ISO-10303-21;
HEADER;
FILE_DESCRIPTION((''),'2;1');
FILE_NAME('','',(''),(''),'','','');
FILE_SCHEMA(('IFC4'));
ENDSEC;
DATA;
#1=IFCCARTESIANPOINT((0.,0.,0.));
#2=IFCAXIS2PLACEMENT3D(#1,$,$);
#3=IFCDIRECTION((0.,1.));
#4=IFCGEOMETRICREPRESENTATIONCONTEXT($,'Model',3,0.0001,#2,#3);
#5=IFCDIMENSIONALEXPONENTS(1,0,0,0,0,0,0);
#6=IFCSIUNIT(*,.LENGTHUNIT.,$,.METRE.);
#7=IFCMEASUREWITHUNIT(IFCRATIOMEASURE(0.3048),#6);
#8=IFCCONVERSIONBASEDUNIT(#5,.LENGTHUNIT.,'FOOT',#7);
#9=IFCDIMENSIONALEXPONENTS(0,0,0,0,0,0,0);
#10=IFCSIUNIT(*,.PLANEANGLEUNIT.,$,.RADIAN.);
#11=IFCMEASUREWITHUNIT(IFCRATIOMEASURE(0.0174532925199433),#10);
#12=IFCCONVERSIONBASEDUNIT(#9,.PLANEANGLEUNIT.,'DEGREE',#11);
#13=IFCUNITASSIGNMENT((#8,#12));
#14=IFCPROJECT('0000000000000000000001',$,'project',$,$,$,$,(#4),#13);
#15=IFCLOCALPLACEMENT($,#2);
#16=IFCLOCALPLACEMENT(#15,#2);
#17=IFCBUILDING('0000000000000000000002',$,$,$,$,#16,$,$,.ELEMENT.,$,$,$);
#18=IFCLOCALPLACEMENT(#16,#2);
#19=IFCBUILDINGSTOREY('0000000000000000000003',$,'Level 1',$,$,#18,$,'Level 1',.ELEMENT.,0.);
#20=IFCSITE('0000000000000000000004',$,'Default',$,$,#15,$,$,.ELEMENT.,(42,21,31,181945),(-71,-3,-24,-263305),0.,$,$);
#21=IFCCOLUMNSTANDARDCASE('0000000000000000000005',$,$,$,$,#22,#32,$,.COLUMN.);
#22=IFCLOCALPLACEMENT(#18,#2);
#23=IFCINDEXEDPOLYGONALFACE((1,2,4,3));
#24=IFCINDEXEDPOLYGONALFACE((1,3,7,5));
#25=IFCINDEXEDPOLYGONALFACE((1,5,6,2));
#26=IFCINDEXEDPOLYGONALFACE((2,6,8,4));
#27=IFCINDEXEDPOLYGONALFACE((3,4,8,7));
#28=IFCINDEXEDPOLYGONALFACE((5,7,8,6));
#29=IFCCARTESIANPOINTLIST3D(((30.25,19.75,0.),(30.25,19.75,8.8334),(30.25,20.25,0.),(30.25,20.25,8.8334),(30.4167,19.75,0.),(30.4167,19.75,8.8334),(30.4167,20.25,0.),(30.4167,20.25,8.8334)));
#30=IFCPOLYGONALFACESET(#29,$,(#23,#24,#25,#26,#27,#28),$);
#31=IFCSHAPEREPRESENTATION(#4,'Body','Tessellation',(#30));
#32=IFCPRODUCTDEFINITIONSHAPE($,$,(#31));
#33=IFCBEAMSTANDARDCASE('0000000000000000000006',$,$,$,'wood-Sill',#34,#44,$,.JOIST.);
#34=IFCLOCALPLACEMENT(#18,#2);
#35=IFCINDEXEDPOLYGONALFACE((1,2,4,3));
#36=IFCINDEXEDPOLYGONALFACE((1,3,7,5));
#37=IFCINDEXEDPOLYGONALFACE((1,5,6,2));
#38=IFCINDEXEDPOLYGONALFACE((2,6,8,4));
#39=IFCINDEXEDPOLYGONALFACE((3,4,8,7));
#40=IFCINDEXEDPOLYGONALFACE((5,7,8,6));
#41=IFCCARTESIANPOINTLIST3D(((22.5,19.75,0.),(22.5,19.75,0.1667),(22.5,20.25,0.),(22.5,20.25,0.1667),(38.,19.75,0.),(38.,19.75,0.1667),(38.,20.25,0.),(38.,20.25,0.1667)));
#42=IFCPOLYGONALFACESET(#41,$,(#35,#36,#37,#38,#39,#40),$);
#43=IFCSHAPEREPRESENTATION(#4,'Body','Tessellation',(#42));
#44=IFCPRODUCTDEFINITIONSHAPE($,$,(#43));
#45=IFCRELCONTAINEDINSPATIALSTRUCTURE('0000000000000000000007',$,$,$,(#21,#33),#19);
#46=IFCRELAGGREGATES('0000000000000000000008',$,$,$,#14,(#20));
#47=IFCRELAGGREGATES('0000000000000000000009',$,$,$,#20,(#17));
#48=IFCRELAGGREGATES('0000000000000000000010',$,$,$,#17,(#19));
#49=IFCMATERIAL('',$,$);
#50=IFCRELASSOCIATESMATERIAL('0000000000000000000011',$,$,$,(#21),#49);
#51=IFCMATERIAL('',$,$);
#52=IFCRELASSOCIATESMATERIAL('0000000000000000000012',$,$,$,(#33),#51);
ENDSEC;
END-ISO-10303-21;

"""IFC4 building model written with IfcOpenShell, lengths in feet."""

from ifc_helpers import new_model, entity, si_unit, converted_unit, direction, frame, origin, origin_with_axes, place, context, project, spatial, rectangle, extrude, material, element, save


model = new_model("IFC4")

# Units and contexts
model_context = context("Model", 3, precision=0.0001, world=origin(), true_north=direction((0.0, 1.0)))
ifc_project = project(units=[converted_unit("LENGTHUNIT", "FOOT", entity("IfcRatioMeasure", 0.3048), si_unit("LENGTHUNIT", "METRE"), dimensions=[1, 0, 0, 0, 0, 0, 0]), converted_unit("PLANEANGLEUNIT", "DEGREE", entity("IfcRatioMeasure", 0.0174532925199433), si_unit("PLANEANGLEUNIT", "RADIAN"), dimensions=[0, 0, 0, 0, 0, 0, 0])], contexts=[model_context])

# Site, building, storey
site_placement = place(None, origin())
site = spatial("IfcSite", under=ifc_project, at=site_placement, Name="Default", CompositionType="ELEMENT", RefLatitude=(42, 21, 31, 181945), RefLongitude=(-71, -3, -24, -263305), RefElevation=0.0)
building_placement = place(site_placement, origin())
building = spatial("IfcBuilding", under=site, at=building_placement, CompositionType="ELEMENT")
storey_placement = place(building_placement, origin())
storey = spatial("IfcBuildingStorey", under=building, at=storey_placement, Name="Level 1", LongName="Level 1", CompositionType="ELEMENT", Elevation=0.0)

# Column
ifc_material_1 = material(Name="")
placement_1 = place(storey_placement, frame((30.25, 20.0, 0.0)))
for number, where, z_axis, x_axis in (
    (1, (0.0833, 0.0, 0.0), (0.0, 0.0, 1.0), (1.0, 0.0, 0.0)),
):
    element("IfcColumnStandardCase", number, at=place(placement_1, frame(where, z_axis=z_axis, x_axis=x_axis)), inside=storey, material=ifc_material_1, PredefinedType="COLUMN", context=model_context, shape_type="SweptSolid", body=[
        extrude(rectangle(XDim=0.1667, YDim=0.5), origin(), (0.0, 0.0, 1.0), 8.8334),
    ])

# Beam
ifc_material_2 = material(Name="")
beam_1_placement = place(placement_1, origin_with_axes())
element("IfcBeamStandardCase", 2, at=beam_1_placement, inside=storey, material=ifc_material_2, ObjectType="wood-Sill", PredefinedType="JOIST", context=model_context, shape_type="SweptSolid", body=[
    extrude(rectangle(XDim=15.5, YDim=0.5), origin(), (0.0, 0.0, 1.0), 0.1667),
])

save(model, "model.ifc")
